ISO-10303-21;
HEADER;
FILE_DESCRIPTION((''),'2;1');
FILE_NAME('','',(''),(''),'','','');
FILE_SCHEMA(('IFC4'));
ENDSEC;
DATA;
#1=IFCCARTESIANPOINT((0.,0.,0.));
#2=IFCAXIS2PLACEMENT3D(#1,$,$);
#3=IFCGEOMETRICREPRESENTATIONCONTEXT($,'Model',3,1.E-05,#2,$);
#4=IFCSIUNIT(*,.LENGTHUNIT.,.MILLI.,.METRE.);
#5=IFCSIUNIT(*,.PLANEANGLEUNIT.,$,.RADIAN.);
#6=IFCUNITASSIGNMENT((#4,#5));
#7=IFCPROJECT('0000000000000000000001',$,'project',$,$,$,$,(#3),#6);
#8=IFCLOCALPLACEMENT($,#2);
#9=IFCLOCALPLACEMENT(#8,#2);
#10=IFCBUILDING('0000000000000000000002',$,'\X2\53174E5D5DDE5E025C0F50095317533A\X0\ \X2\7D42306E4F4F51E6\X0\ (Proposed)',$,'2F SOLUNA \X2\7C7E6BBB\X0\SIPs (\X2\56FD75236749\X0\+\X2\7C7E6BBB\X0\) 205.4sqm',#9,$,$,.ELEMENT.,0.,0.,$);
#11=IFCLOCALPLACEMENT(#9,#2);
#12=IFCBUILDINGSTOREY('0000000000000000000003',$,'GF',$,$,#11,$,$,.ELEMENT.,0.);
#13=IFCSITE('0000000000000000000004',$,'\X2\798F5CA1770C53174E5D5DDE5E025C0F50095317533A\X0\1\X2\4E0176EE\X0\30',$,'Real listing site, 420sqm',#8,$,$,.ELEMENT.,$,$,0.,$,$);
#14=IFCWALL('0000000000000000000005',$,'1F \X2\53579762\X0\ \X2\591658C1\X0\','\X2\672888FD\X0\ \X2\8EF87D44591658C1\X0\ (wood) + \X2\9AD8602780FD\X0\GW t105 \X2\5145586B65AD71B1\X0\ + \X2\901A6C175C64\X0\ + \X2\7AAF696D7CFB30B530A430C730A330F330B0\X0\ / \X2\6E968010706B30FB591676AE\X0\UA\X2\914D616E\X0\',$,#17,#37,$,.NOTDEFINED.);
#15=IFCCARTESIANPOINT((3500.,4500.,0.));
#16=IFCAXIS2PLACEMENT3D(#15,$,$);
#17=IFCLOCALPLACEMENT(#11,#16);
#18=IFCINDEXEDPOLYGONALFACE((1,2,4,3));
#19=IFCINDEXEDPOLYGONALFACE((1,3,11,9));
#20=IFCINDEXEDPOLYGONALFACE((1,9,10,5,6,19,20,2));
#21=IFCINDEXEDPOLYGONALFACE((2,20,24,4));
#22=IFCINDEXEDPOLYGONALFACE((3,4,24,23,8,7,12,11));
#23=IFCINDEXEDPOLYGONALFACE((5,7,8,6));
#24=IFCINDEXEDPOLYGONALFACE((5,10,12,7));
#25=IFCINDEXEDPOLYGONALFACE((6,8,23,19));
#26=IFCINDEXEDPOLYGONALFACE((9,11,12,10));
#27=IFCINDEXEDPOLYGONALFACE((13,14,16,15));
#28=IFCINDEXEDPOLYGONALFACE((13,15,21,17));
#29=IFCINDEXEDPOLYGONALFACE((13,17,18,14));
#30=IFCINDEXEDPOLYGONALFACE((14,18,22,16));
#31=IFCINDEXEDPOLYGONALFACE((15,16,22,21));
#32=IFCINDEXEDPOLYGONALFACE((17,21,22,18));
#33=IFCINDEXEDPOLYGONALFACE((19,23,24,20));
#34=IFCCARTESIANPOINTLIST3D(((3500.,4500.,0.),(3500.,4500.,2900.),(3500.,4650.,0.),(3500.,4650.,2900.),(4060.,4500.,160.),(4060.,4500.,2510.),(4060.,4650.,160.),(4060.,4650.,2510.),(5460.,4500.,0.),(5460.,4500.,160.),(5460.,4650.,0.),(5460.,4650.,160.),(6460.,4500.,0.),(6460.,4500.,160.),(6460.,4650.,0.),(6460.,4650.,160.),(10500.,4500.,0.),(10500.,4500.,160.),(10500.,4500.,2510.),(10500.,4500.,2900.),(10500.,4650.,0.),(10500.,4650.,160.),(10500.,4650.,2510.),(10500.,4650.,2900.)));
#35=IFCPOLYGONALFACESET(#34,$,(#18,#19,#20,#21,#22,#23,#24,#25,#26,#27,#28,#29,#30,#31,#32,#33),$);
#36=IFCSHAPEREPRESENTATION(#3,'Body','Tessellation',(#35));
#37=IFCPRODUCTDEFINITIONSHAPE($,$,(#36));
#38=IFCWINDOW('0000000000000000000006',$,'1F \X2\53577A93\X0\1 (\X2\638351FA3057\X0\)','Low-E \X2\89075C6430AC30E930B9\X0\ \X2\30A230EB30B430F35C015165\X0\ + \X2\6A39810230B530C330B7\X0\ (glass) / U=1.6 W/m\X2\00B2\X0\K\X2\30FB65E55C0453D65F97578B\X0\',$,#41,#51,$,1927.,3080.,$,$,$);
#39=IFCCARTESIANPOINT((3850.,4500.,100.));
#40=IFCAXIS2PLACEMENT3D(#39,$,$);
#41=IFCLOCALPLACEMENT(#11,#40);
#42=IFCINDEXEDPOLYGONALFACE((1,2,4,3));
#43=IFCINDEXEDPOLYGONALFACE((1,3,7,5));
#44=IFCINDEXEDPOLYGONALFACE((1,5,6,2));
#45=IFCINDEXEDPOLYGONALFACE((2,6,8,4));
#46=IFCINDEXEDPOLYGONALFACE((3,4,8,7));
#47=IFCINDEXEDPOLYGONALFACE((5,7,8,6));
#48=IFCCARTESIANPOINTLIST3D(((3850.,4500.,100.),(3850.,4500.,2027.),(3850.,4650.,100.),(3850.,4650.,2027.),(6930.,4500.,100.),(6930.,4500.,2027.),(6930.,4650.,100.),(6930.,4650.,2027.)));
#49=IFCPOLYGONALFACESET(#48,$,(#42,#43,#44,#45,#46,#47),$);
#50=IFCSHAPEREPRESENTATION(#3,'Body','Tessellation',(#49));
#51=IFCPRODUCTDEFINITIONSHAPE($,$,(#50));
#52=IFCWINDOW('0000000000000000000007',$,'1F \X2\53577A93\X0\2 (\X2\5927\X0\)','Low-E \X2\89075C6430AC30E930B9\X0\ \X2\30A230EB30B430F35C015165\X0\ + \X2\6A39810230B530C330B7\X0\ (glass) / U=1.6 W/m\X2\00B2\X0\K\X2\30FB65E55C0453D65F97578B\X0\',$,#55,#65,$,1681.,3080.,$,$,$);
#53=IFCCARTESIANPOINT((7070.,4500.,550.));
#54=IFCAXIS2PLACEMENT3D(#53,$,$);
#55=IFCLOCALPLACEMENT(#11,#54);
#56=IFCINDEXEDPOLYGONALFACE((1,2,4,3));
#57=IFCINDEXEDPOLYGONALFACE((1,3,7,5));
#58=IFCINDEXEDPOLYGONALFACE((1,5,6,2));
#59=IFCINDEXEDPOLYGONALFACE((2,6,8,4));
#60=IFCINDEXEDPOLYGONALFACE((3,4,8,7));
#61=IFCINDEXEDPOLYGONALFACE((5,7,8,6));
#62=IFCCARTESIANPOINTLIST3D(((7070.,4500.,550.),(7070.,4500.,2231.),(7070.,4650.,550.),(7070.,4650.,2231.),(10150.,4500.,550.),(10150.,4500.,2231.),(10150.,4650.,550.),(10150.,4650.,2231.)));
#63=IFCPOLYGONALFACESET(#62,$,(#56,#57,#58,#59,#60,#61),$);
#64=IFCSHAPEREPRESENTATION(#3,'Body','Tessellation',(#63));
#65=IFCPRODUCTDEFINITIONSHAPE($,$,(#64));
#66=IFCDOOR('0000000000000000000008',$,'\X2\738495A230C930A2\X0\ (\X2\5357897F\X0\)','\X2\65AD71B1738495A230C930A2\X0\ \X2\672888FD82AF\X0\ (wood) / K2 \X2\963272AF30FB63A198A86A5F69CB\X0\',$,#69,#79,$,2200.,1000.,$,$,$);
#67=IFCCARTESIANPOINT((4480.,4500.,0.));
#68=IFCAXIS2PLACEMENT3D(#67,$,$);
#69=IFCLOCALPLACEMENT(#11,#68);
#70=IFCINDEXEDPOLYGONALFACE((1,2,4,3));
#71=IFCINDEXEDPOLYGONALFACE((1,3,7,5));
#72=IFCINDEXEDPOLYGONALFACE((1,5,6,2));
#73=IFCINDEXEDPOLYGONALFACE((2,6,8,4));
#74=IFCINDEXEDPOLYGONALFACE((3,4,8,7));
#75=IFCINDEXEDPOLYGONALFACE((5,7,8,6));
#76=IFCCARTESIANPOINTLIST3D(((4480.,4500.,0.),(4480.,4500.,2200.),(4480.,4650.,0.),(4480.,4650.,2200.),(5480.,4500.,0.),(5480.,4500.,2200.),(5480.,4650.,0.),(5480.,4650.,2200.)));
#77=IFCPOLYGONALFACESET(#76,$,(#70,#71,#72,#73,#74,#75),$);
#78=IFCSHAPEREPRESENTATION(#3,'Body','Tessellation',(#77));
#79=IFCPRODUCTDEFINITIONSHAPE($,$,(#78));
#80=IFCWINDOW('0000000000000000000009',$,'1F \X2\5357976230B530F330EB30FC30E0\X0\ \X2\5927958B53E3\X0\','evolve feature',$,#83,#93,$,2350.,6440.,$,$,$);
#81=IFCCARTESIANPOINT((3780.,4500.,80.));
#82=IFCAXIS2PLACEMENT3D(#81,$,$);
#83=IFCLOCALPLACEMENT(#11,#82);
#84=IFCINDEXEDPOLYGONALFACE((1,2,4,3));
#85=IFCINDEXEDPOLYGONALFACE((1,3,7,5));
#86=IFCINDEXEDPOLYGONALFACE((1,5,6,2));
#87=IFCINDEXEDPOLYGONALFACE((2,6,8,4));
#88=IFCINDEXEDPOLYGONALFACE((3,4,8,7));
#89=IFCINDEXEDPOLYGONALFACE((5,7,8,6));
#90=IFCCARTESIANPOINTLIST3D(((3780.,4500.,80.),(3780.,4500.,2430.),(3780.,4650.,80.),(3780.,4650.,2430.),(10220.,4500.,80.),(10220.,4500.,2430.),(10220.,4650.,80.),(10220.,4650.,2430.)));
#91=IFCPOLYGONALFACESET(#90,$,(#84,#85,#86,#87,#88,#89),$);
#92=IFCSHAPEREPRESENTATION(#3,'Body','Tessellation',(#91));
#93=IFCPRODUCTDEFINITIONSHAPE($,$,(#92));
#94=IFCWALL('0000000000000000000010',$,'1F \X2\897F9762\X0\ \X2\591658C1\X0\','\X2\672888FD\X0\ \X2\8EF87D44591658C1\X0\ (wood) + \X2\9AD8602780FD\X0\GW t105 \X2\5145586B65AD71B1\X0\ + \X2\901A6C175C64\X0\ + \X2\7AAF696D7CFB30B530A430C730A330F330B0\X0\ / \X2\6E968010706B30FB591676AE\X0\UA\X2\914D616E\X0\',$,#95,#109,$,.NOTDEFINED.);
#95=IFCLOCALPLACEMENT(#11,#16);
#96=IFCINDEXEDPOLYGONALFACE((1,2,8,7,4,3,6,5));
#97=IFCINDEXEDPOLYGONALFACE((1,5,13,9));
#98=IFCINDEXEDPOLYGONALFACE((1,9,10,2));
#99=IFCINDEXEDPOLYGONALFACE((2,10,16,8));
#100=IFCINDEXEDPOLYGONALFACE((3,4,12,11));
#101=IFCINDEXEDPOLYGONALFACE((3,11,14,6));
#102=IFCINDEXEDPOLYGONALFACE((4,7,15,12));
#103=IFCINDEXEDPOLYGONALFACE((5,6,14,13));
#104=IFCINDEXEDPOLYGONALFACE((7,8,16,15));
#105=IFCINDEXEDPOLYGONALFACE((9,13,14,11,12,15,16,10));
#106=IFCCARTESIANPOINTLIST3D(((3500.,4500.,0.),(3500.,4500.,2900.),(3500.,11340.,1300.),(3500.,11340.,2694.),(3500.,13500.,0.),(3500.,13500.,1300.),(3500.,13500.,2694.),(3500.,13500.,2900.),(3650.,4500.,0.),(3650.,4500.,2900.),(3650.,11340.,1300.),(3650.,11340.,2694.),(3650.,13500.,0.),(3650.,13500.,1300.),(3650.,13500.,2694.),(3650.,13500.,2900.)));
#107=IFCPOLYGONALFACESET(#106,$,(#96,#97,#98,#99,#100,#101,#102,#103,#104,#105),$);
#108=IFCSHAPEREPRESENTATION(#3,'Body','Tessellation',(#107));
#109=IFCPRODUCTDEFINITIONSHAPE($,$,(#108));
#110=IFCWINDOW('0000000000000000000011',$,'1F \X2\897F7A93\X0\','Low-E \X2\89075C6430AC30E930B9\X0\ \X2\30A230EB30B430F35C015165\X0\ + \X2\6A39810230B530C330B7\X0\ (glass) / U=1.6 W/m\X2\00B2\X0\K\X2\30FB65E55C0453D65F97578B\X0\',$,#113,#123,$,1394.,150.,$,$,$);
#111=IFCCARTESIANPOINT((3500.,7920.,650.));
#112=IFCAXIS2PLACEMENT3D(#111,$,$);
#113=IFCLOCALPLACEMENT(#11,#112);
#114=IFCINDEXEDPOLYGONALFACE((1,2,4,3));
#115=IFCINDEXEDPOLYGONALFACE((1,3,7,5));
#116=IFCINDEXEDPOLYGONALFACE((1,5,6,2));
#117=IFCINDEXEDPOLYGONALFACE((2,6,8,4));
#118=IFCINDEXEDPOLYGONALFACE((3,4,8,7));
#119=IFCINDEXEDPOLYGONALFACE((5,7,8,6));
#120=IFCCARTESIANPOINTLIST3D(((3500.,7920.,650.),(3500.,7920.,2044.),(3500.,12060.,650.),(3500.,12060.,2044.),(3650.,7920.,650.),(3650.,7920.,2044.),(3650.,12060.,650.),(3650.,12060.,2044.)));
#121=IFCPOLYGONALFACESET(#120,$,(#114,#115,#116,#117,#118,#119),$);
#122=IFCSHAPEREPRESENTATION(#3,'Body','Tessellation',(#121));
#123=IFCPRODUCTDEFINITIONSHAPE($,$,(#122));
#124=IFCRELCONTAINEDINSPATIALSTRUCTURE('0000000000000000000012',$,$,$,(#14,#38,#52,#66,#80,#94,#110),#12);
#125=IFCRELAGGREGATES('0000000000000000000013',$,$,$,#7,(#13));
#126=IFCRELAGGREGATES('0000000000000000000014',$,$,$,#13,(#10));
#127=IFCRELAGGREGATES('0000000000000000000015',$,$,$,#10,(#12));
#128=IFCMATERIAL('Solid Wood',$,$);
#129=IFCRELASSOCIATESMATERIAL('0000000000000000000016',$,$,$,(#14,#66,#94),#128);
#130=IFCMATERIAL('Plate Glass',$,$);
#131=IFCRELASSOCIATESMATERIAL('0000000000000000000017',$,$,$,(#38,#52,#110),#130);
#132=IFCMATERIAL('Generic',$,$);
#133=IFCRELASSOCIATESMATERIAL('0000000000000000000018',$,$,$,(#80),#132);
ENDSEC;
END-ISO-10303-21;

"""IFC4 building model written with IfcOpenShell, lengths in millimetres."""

from ifc_helpers import new_model, si_unit, frame, frame_2d, origin, place, context, project, spatial, rectangle, extrude, material, element, fill, save


model = new_model("IFC4")

# Units and contexts
model_context = context("Model", 3, precision=1e-05, world=origin())
ifc_project = project(units=[si_unit("LENGTHUNIT", "METRE", prefix="MILLI"), si_unit("PLANEANGLEUNIT", "RADIAN")], contexts=[model_context])

# Site, building, storey
site_placement = place(None, origin())
site = spatial("IfcSite", under=ifc_project, at=site_placement, Name="福岡県北九州市小倉北区1丁目30", ObjectType="Real listing site, 420sqm", CompositionType="ELEMENT", RefElevation=0.0)
building_placement = place(site_placement, origin())
building = spatial("IfcBuilding", under=site, at=building_placement, Name="北九州市小倉北区 終の住処 (Proposed)", ObjectType="2F SOLUNA 籾殻SIPs (国産杉+籾殻) 205.4sqm", CompositionType="ELEMENT", ElevationOfRefHeight=0.0, ElevationOfTerrain=0.0)
storey_placement = place(building_placement, origin())
storey = spatial("IfcBuildingStorey", under=building, at=storey_placement, Name="GF", CompositionType="ELEMENT", Elevation=0.0)

# Shared definitions
ifc_material_1 = material(Name="Solid Wood")
ifc_material_2 = material(Name="Generic")

# Wall, openings, windows, door
wall_1_placement = place(storey_placement, frame((3500.0, 4500.0, 0.0)))
wall_1 = element("IfcWall", 1, at=wall_1_placement, inside=storey, material=ifc_material_1, Name="1F 南面 外壁", Description="木製 軸組外壁 (wood) + 高性能GW t105 充填断熱 + 通気層 + 窯業系サイディング / 準耐火・外皮UA配慮", PredefinedType="NOTDEFINED", context=model_context, shape_type="SweptSolid", body=[
    extrude(rectangle(XDim=7000.0, YDim=150.0, at=frame_2d((3500.0, 75.0))), frame((3500.0, 4500.0, 0.0)), (0.0, 0.0, 1.0), 2900.0),
])
opening_1_placement = place(storey_placement, frame((3850.0, 4500.0, 100.0)))
opening_1 = element("IfcOpeningElement", 2, at=opening_1_placement, cuts=wall_1, PredefinedType="NOTDEFINED", context=model_context, shape_type="SweptSolid", body=[
    extrude(rectangle(XDim=3080.0, YDim=150.0, at=frame_2d((1540.0, 75.0))), frame((3850.0, 4500.0, 100.0)), (0.0, 0.0, 1.0), 1927.0),
])
opening_2_placement = place(storey_placement, frame((7070.0, 4500.0, 550.0)))
opening_2 = element("IfcOpeningElement", 3, at=opening_2_placement, cuts=wall_1, PredefinedType="NOTDEFINED", context=model_context, shape_type="SweptSolid", body=[
    extrude(rectangle(XDim=3080.0, YDim=150.0, at=frame_2d((1540.0, 75.0))), frame((7070.0, 4500.0, 550.0)), (0.0, 0.0, 1.0), 1681.0),
])
opening_3_placement = place(storey_placement, frame((4480.0, 4500.0, 0.0)))
opening_3 = element("IfcOpeningElement", 4, at=opening_3_placement, cuts=wall_1, PredefinedType="NOTDEFINED", context=model_context, shape_type="SweptSolid", body=[
    extrude(rectangle(XDim=1000.0, YDim=150.0, at=frame_2d((500.0, 75.0))), frame((4480.0, 4500.0, 0.0)), (0.0, 0.0, 1.0), 2200.0),
])
opening_4_placement = place(storey_placement, frame((3780.0, 4500.0, 80.0)))
opening_4 = element("IfcOpeningElement", 5, at=opening_4_placement, cuts=wall_1, PredefinedType="NOTDEFINED", context=model_context, shape_type="SweptSolid", body=[
    extrude(rectangle(XDim=6440.0, YDim=150.0, at=frame_2d((3220.0, 75.0))), frame((3780.0, 4500.0, 80.0)), (0.0, 0.0, 1.0), 2350.0),
])
ifc_material_3 = material(Name="Plate Glass")
window_1_placement = place(storey_placement, frame((3850.0, 4500.0, 100.0)))
window_1 = element("IfcWindow", 6, at=window_1_placement, inside=storey, material=ifc_material_3, Name="1F 南窓1 (掃出し)", Description="Low-E 複層ガラス アルゴン封入 + 樹脂サッシ (glass) / U=1.6 W/m²K・日射取得型", OverallHeight=1927.0, OverallWidth=3080.0, context=model_context, shape_type="SweptSolid", body=[
    extrude(rectangle(XDim=3080.0, YDim=150.0, at=frame_2d((1540.0, 75.0))), frame((3850.0, 4500.0, 100.0)), (0.0, 0.0, 1.0), 1927.0),
])
fill(opening_1, window_1)
window_2_placement = place(storey_placement, frame((7070.0, 4500.0, 550.0)))
window_2 = element("IfcWindow", 7, at=window_2_placement, inside=storey, material=ifc_material_3, Name="1F 南窓2 (大)", Description="Low-E 複層ガラス アルゴン封入 + 樹脂サッシ (glass) / U=1.6 W/m²K・日射取得型", OverallHeight=1681.0, OverallWidth=3080.0, context=model_context, shape_type="SweptSolid", body=[
    extrude(rectangle(XDim=3080.0, YDim=150.0, at=frame_2d((1540.0, 75.0))), frame((7070.0, 4500.0, 550.0)), (0.0, 0.0, 1.0), 1681.0),
])
fill(opening_2, window_2)
door_placement = place(storey_placement, frame((4480.0, 4500.0, 0.0)))
door = element("IfcDoor", 8, at=door_placement, inside=storey, material=ifc_material_1, Name="玄関ドア (南西)", Description="断熱玄関ドア 木製芯 (wood) / K2 防犯・採風機構", OverallHeight=2200.0, OverallWidth=1000.0, context=model_context, shape_type="SweptSolid", body=[
    extrude(rectangle(XDim=1000.0, YDim=150.0, at=frame_2d((500.0, 75.0))), frame((4480.0, 4500.0, 0.0)), (0.0, 0.0, 1.0), 2200.0),
])
fill(opening_3, door)
window_3_placement = place(storey_placement, frame((3780.0, 4500.0, 80.0)))
window_3 = element("IfcWindow", 9, at=window_3_placement, inside=storey, material=ifc_material_2, Name="1F 南面サンルーム 大開口", Description="evolve feature", OverallHeight=2350.0, OverallWidth=6440.0, context=model_context, shape_type="SweptSolid", body=[
    extrude(rectangle(XDim=6440.0, YDim=150.0, at=frame_2d((3220.0, 75.0))), frame((3780.0, 4500.0, 80.0)), (0.0, 0.0, 1.0), 2350.0),
])
fill(opening_4, window_3)

# Wall, opening, window
wall_2_placement = place(storey_placement, frame((3500.0, 4500.0, 0.0)))
wall_2 = element("IfcWall", 10, at=wall_2_placement, inside=storey, material=ifc_material_1, Name="1F 西面 外壁", Description="木製 軸組外壁 (wood) + 高性能GW t105 充填断熱 + 通気層 + 窯業系サイディング / 準耐火・外皮UA配慮", PredefinedType="NOTDEFINED", context=model_context, shape_type="SweptSolid", body=[
    extrude(rectangle(XDim=150.0, YDim=9000.0, at=frame_2d((75.0, 4500.0))), frame((3500.0, 4500.0, 0.0)), (0.0, 0.0, 1.0), 2900.0),
])
opening_5_placement = place(storey_placement, frame((3500.0, 7920.0, 650.0)))
opening_5 = element("IfcOpeningElement", 11, at=opening_5_placement, cuts=wall_2, PredefinedType="NOTDEFINED", context=model_context, shape_type="SweptSolid", body=[
    extrude(rectangle(XDim=150.0, YDim=4140.0, at=frame_2d((75.0, 2070.0))), frame((3500.0, 7920.0, 650.0)), (0.0, 0.0, 1.0), 1394.0),
])
window_4_placement = place(storey_placement, frame((3500.0, 7920.0, 650.0)))
window_4 = element("IfcWindow", 12, at=window_4_placement, inside=storey, material=ifc_material_3, Name="1F 西窓", Description="Low-E 複層ガラス アルゴン封入 + 樹脂サッシ (glass) / U=1.6 W/m²K・日射取得型", OverallHeight=1394.0, OverallWidth=150.0, context=model_context, shape_type="SweptSolid", body=[
    extrude(rectangle(XDim=150.0, YDim=4140.0, at=frame_2d((75.0, 2070.0))), frame((3500.0, 7920.0, 650.0)), (0.0, 0.0, 1.0), 1394.0),
])
fill(opening_5, window_4)

save(model, "model.ifc")
